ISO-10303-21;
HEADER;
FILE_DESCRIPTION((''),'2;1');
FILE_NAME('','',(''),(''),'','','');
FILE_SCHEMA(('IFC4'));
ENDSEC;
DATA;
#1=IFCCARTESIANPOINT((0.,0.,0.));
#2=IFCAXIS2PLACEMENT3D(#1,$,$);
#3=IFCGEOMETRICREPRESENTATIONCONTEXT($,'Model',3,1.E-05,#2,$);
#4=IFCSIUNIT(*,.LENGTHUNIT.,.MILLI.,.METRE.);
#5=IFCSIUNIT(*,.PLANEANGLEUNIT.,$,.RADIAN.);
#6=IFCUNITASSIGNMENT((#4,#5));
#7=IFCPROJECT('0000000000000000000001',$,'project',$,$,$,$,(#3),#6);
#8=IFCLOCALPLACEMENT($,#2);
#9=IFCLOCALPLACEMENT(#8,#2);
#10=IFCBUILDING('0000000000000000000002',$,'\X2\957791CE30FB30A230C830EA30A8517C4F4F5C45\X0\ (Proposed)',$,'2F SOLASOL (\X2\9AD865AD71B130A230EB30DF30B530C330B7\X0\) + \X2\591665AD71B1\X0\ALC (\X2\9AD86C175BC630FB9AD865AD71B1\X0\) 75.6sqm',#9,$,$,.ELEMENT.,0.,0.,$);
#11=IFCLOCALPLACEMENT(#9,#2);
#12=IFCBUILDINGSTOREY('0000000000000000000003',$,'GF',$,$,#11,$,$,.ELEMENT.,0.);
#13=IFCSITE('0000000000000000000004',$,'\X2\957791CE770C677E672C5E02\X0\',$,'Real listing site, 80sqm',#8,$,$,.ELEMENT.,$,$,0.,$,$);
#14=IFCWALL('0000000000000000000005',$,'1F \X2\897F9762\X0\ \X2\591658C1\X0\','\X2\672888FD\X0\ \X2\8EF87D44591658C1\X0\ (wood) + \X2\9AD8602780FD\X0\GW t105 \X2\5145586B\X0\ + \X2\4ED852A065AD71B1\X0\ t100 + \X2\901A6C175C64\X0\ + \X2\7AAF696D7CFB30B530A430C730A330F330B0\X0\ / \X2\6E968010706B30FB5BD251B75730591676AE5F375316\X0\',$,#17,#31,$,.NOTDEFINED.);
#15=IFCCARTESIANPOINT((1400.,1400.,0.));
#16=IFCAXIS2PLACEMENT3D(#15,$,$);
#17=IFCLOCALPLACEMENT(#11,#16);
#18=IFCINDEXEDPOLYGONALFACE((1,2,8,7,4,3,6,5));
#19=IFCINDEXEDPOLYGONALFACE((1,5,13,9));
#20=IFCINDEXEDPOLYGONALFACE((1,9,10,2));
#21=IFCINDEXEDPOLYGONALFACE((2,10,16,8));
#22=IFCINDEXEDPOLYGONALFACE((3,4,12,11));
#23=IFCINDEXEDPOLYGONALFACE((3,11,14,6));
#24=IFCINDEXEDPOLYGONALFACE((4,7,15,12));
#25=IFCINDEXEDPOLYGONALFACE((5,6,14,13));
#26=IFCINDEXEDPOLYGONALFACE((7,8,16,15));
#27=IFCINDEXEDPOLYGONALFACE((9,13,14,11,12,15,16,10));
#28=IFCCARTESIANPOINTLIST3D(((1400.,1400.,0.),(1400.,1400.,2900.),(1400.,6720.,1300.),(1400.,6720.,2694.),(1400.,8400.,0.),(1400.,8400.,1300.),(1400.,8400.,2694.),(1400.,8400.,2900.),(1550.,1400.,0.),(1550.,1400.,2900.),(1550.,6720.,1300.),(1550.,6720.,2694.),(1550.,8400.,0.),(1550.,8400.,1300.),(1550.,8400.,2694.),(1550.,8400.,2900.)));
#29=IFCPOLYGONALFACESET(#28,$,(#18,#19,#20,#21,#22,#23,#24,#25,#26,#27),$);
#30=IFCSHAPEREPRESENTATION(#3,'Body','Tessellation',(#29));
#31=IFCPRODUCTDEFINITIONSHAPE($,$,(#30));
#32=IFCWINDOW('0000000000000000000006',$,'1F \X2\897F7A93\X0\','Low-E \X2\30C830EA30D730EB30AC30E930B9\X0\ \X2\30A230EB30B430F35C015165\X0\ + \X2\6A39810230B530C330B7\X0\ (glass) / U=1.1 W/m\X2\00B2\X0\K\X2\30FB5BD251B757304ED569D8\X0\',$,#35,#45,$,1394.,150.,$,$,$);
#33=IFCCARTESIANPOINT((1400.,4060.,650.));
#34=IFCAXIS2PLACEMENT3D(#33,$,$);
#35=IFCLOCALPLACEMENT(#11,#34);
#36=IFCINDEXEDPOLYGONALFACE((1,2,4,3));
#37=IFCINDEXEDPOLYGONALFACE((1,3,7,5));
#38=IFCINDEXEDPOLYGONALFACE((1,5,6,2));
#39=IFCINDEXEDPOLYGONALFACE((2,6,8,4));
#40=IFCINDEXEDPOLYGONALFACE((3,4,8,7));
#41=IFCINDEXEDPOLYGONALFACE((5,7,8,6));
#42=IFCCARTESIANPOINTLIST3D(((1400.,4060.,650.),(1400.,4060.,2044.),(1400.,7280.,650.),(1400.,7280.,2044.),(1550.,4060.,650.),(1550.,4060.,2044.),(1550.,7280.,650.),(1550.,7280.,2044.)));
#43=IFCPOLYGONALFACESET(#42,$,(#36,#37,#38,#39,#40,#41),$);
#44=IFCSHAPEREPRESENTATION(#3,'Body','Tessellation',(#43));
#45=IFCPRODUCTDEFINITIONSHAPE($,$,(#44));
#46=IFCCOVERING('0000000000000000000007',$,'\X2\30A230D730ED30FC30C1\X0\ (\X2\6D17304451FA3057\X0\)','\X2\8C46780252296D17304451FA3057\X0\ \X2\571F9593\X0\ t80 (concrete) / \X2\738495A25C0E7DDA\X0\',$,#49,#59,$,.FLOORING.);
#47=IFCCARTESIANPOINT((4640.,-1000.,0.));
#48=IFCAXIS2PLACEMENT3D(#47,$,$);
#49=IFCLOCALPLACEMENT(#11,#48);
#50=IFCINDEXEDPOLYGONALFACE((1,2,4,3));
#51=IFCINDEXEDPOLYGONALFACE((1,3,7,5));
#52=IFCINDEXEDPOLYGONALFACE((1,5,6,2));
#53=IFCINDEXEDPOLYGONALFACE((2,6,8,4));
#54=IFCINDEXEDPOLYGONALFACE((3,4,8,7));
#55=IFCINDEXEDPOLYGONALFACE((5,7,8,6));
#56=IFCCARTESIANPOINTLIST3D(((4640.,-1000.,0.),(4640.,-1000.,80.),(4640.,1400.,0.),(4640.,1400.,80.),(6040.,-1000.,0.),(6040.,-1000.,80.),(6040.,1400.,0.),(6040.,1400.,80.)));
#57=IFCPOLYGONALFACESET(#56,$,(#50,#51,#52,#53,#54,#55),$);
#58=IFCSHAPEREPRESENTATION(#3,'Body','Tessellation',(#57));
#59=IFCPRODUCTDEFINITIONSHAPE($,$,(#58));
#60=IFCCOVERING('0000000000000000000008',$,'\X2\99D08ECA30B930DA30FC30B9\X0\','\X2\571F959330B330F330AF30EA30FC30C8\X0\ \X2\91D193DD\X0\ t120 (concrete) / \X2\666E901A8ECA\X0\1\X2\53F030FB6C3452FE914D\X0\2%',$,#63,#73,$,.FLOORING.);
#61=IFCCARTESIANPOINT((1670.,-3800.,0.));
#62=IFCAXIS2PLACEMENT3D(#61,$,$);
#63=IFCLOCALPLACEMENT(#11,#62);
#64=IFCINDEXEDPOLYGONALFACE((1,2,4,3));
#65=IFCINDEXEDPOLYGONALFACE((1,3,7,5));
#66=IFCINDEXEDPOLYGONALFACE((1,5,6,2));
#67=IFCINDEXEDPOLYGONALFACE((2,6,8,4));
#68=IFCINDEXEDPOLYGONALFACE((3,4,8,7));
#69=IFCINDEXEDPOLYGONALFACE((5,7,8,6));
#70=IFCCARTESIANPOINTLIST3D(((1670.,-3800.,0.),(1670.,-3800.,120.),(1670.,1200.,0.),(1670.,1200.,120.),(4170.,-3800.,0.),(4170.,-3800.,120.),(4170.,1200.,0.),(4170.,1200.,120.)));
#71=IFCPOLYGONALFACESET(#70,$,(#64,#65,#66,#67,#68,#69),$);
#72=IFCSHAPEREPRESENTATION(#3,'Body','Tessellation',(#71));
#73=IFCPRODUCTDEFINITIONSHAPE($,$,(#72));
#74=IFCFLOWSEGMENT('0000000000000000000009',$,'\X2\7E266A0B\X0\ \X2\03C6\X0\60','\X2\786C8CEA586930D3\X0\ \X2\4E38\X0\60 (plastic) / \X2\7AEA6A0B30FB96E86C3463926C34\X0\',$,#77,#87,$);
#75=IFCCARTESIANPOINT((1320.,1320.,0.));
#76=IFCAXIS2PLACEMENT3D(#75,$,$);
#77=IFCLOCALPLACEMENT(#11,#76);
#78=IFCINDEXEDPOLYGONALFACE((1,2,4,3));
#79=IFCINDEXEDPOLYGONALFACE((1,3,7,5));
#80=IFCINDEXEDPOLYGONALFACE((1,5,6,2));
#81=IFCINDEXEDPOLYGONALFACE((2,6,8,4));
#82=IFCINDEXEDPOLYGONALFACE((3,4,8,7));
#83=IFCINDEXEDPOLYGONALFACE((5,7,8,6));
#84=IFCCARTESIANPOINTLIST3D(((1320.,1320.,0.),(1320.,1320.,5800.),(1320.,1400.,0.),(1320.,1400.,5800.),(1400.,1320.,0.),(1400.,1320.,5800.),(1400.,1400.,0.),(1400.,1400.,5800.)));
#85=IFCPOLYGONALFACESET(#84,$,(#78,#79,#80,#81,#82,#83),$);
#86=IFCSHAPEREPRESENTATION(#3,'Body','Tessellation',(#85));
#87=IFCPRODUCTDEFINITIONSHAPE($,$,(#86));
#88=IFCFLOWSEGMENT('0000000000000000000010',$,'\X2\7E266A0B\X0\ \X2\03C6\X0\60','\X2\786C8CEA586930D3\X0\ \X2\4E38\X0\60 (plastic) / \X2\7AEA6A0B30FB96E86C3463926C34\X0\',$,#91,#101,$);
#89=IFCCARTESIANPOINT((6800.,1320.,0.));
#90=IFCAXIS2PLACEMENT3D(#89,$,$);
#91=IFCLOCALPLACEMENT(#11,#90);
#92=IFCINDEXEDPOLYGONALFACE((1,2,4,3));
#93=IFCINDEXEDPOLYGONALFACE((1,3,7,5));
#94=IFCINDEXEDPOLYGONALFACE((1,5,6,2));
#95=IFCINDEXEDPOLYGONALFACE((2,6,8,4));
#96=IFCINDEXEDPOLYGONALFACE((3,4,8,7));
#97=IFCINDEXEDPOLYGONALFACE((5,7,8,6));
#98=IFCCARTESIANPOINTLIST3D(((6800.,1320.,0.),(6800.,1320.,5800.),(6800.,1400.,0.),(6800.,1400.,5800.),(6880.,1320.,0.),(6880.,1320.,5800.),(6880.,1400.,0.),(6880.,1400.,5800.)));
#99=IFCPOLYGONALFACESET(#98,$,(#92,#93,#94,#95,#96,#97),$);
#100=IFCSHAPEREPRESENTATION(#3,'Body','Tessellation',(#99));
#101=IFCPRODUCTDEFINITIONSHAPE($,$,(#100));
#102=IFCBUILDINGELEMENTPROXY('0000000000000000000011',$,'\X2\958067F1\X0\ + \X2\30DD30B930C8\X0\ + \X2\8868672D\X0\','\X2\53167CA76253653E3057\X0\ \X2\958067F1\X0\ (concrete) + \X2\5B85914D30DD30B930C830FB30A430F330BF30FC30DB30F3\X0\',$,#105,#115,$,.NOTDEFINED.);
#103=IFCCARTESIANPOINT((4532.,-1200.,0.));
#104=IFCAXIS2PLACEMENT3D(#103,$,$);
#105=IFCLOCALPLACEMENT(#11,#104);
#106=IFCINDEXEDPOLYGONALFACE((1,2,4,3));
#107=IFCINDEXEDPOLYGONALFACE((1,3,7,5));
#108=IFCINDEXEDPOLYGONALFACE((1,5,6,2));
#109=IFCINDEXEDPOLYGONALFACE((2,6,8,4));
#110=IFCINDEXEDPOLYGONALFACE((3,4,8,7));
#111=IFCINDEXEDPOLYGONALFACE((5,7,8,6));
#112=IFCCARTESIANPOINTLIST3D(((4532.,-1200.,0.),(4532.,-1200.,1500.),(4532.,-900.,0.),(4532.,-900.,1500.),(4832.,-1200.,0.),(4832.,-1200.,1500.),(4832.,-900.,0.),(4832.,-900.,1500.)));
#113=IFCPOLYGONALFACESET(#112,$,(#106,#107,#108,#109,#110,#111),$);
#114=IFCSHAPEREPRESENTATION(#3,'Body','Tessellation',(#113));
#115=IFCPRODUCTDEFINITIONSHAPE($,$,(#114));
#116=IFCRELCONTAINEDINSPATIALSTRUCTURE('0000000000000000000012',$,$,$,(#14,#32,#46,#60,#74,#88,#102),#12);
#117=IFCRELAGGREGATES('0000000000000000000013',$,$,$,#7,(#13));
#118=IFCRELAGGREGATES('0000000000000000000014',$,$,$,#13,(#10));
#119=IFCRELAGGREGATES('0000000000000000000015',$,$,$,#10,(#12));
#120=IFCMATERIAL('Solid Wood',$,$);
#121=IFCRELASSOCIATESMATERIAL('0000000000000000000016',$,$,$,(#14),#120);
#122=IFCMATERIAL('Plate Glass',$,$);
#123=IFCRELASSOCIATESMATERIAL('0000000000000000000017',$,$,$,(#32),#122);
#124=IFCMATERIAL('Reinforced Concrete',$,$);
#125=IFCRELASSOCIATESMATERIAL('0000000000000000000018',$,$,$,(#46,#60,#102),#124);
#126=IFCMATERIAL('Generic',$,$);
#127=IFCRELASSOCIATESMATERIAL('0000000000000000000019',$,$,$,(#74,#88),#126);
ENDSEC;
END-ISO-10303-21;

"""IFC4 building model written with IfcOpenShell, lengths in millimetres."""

from ifc_helpers import new_model, si_unit, frame, frame_2d, origin, place, context, project, spatial, rectangle, extrude, material, element, fill, save


model = new_model("IFC4")

# Units and contexts
model_context = context("Model", 3, precision=1e-05, world=origin())
ifc_project = project(units=[si_unit("LENGTHUNIT", "METRE", prefix="MILLI"), si_unit("PLANEANGLEUNIT", "RADIAN")], contexts=[model_context])

# Site, building, storey
site_placement = place(None, origin())
site = spatial("IfcSite", under=ifc_project, at=site_placement, Name="長野県松本市", ObjectType="Real listing site, 80sqm", CompositionType="ELEMENT", RefElevation=0.0)
building_placement = place(site_placement, origin())
building = spatial("IfcBuilding", under=site, at=building_placement, Name="長野・アトリエ兼住居 (Proposed)", ObjectType="2F SOLASOL (高断熱アルミサッシ) + 外断熱ALC (高気密・高断熱) 75.6sqm", CompositionType="ELEMENT", ElevationOfRefHeight=0.0, ElevationOfTerrain=0.0)
storey_placement = place(building_placement, origin())
storey = spatial("IfcBuildingStorey", under=building, at=storey_placement, Name="GF", CompositionType="ELEMENT", Elevation=0.0)

# Shared definitions
ifc_material_1 = material(Name="Solid Wood")

# Shared definitions
ifc_material_2 = material(Name="Reinforced Concrete")

# Shared definitions
ifc_material_3 = material(Name="Plate Glass")

# Wall, opening, window
wall_1_placement = place(storey_placement, frame((1400.0, 1400.0, 0.0)))
wall_1 = element("IfcWall", 1, at=wall_1_placement, inside=storey, material=ifc_material_1, Name="1F 西面 外壁", Description="木製 軸組外壁 (wood) + 高性能GW t105 充填 + 付加断熱 t100 + 通気層 + 窯業系サイディング / 準耐火・寒冷地外皮強化", PredefinedType="NOTDEFINED", context=model_context, shape_type="SweptSolid", body=[
    extrude(rectangle(XDim=150.0, YDim=7000.0, at=frame_2d((75.0, 3500.0))), frame((1400.0, 1400.0, 0.0)), (0.0, 0.0, 1.0), 2900.0),
])
opening_1_placement = place(storey_placement, frame((1400.0, 4060.0, 650.0)))
opening_1 = element("IfcOpeningElement", 2, at=opening_1_placement, cuts=wall_1, PredefinedType="NOTDEFINED", context=model_context, shape_type="SweptSolid", body=[
    extrude(rectangle(XDim=150.0, YDim=3220.0, at=frame_2d((75.0, 1610.0))), frame((1400.0, 4060.0, 650.0)), (0.0, 0.0, 1.0), 1394.0),
])
window_1_placement = place(storey_placement, frame((1400.0, 4060.0, 650.0)))
window_1 = element("IfcWindow", 3, at=window_1_placement, inside=storey, material=ifc_material_3, Name="1F 西窓", Description="Low-E トリプルガラス アルゴン封入 + 樹脂サッシ (glass) / U=1.1 W/m²K・寒冷地仕様", OverallHeight=1394.0, OverallWidth=150.0, context=model_context, shape_type="SweptSolid", body=[
    extrude(rectangle(XDim=150.0, YDim=3220.0, at=frame_2d((75.0, 1610.0))), frame((1400.0, 4060.0, 650.0)), (0.0, 0.0, 1.0), 1394.0),
])
fill(opening_1, window_1)

# Coverings
covering_1_placement = place(storey_placement, frame((4640.0, -1000.0, 0.0)))
element("IfcCovering", 4, at=covering_1_placement, inside=storey, material=ifc_material_2, Name="アプローチ (洗い出し)", Description="豆砂利洗い出し 土間 t80 (concrete) / 玄関導線", PredefinedType="FLOORING", context=model_context, shape_type="SweptSolid", body=[
    extrude(rectangle(XDim=1400.0, YDim=2400.0, at=frame_2d((700.0, 1200.0))), frame((4640.0, -1000.0, 0.0)), (0.0, 0.0, 1.0), 80.0),
])
covering_2_placement = place(storey_placement, frame((1670.0, -3800.0, 0.0)))
element("IfcCovering", 5, at=covering_2_placement, inside=storey, material=ifc_material_2, Name="駐車スペース", Description="土間コンクリート 金鏝 t120 (concrete) / 普通車1台・水勾配2%", PredefinedType="FLOORING", context=model_context, shape_type="SweptSolid", body=[
    extrude(rectangle(XDim=2500.0, YDim=5000.0, at=frame_2d((1250.0, 2500.0))), frame((1670.0, -3800.0, 0.0)), (0.0, 0.0, 1.0), 120.0),
])

# Flow segments
ifc_material_4 = material(Name="Generic")
flow_segment_1_placement = place(storey_placement, frame((1320.0, 1320.0, 0.0)))
element("IfcFlowSegment", 6, at=flow_segment_1_placement, inside=storey, material=ifc_material_4, Name="縦樋 φ60", Description="硬質塩ビ 丸60 (plastic) / 竪樋・雨水排水", context=model_context, shape_type="SweptSolid", body=[
    extrude(rectangle(XDim=80.0, YDim=80.0, at=frame_2d((40.0, 40.0))), frame((1320.0, 1320.0, 0.0)), (0.0, 0.0, 1.0), 5800.0),
])
flow_segment_2_placement = place(storey_placement, frame((6800.0, 1320.0, 0.0)))
element("IfcFlowSegment", 7, at=flow_segment_2_placement, inside=storey, material=ifc_material_4, Name="縦樋 φ60", Description="硬質塩ビ 丸60 (plastic) / 竪樋・雨水排水", context=model_context, shape_type="SweptSolid", body=[
    extrude(rectangle(XDim=80.0, YDim=80.0, at=frame_2d((40.0, 40.0))), frame((6800.0, 1320.0, 0.0)), (0.0, 0.0, 1.0), 5800.0),
])

# Building element proxy
proxy_placement = place(storey_placement, frame((4532.0, -1200.0, 0.0)))
element("IfcBuildingElementProxy", 8, at=proxy_placement, inside=storey, material=ifc_material_2, Name="門柱 + ポスト + 表札", Description="化粧打放し 門柱 (concrete) + 宅配ポスト・インターホン", PredefinedType="NOTDEFINED", context=model_context, shape_type="SweptSolid", body=[
    extrude(rectangle(XDim=300.0, YDim=300.0, at=frame_2d((150.0, 150.0))), frame((4532.0, -1200.0, 0.0)), (0.0, 0.0, 1.0), 1500.0),
])

save(model, "model.ifc")
